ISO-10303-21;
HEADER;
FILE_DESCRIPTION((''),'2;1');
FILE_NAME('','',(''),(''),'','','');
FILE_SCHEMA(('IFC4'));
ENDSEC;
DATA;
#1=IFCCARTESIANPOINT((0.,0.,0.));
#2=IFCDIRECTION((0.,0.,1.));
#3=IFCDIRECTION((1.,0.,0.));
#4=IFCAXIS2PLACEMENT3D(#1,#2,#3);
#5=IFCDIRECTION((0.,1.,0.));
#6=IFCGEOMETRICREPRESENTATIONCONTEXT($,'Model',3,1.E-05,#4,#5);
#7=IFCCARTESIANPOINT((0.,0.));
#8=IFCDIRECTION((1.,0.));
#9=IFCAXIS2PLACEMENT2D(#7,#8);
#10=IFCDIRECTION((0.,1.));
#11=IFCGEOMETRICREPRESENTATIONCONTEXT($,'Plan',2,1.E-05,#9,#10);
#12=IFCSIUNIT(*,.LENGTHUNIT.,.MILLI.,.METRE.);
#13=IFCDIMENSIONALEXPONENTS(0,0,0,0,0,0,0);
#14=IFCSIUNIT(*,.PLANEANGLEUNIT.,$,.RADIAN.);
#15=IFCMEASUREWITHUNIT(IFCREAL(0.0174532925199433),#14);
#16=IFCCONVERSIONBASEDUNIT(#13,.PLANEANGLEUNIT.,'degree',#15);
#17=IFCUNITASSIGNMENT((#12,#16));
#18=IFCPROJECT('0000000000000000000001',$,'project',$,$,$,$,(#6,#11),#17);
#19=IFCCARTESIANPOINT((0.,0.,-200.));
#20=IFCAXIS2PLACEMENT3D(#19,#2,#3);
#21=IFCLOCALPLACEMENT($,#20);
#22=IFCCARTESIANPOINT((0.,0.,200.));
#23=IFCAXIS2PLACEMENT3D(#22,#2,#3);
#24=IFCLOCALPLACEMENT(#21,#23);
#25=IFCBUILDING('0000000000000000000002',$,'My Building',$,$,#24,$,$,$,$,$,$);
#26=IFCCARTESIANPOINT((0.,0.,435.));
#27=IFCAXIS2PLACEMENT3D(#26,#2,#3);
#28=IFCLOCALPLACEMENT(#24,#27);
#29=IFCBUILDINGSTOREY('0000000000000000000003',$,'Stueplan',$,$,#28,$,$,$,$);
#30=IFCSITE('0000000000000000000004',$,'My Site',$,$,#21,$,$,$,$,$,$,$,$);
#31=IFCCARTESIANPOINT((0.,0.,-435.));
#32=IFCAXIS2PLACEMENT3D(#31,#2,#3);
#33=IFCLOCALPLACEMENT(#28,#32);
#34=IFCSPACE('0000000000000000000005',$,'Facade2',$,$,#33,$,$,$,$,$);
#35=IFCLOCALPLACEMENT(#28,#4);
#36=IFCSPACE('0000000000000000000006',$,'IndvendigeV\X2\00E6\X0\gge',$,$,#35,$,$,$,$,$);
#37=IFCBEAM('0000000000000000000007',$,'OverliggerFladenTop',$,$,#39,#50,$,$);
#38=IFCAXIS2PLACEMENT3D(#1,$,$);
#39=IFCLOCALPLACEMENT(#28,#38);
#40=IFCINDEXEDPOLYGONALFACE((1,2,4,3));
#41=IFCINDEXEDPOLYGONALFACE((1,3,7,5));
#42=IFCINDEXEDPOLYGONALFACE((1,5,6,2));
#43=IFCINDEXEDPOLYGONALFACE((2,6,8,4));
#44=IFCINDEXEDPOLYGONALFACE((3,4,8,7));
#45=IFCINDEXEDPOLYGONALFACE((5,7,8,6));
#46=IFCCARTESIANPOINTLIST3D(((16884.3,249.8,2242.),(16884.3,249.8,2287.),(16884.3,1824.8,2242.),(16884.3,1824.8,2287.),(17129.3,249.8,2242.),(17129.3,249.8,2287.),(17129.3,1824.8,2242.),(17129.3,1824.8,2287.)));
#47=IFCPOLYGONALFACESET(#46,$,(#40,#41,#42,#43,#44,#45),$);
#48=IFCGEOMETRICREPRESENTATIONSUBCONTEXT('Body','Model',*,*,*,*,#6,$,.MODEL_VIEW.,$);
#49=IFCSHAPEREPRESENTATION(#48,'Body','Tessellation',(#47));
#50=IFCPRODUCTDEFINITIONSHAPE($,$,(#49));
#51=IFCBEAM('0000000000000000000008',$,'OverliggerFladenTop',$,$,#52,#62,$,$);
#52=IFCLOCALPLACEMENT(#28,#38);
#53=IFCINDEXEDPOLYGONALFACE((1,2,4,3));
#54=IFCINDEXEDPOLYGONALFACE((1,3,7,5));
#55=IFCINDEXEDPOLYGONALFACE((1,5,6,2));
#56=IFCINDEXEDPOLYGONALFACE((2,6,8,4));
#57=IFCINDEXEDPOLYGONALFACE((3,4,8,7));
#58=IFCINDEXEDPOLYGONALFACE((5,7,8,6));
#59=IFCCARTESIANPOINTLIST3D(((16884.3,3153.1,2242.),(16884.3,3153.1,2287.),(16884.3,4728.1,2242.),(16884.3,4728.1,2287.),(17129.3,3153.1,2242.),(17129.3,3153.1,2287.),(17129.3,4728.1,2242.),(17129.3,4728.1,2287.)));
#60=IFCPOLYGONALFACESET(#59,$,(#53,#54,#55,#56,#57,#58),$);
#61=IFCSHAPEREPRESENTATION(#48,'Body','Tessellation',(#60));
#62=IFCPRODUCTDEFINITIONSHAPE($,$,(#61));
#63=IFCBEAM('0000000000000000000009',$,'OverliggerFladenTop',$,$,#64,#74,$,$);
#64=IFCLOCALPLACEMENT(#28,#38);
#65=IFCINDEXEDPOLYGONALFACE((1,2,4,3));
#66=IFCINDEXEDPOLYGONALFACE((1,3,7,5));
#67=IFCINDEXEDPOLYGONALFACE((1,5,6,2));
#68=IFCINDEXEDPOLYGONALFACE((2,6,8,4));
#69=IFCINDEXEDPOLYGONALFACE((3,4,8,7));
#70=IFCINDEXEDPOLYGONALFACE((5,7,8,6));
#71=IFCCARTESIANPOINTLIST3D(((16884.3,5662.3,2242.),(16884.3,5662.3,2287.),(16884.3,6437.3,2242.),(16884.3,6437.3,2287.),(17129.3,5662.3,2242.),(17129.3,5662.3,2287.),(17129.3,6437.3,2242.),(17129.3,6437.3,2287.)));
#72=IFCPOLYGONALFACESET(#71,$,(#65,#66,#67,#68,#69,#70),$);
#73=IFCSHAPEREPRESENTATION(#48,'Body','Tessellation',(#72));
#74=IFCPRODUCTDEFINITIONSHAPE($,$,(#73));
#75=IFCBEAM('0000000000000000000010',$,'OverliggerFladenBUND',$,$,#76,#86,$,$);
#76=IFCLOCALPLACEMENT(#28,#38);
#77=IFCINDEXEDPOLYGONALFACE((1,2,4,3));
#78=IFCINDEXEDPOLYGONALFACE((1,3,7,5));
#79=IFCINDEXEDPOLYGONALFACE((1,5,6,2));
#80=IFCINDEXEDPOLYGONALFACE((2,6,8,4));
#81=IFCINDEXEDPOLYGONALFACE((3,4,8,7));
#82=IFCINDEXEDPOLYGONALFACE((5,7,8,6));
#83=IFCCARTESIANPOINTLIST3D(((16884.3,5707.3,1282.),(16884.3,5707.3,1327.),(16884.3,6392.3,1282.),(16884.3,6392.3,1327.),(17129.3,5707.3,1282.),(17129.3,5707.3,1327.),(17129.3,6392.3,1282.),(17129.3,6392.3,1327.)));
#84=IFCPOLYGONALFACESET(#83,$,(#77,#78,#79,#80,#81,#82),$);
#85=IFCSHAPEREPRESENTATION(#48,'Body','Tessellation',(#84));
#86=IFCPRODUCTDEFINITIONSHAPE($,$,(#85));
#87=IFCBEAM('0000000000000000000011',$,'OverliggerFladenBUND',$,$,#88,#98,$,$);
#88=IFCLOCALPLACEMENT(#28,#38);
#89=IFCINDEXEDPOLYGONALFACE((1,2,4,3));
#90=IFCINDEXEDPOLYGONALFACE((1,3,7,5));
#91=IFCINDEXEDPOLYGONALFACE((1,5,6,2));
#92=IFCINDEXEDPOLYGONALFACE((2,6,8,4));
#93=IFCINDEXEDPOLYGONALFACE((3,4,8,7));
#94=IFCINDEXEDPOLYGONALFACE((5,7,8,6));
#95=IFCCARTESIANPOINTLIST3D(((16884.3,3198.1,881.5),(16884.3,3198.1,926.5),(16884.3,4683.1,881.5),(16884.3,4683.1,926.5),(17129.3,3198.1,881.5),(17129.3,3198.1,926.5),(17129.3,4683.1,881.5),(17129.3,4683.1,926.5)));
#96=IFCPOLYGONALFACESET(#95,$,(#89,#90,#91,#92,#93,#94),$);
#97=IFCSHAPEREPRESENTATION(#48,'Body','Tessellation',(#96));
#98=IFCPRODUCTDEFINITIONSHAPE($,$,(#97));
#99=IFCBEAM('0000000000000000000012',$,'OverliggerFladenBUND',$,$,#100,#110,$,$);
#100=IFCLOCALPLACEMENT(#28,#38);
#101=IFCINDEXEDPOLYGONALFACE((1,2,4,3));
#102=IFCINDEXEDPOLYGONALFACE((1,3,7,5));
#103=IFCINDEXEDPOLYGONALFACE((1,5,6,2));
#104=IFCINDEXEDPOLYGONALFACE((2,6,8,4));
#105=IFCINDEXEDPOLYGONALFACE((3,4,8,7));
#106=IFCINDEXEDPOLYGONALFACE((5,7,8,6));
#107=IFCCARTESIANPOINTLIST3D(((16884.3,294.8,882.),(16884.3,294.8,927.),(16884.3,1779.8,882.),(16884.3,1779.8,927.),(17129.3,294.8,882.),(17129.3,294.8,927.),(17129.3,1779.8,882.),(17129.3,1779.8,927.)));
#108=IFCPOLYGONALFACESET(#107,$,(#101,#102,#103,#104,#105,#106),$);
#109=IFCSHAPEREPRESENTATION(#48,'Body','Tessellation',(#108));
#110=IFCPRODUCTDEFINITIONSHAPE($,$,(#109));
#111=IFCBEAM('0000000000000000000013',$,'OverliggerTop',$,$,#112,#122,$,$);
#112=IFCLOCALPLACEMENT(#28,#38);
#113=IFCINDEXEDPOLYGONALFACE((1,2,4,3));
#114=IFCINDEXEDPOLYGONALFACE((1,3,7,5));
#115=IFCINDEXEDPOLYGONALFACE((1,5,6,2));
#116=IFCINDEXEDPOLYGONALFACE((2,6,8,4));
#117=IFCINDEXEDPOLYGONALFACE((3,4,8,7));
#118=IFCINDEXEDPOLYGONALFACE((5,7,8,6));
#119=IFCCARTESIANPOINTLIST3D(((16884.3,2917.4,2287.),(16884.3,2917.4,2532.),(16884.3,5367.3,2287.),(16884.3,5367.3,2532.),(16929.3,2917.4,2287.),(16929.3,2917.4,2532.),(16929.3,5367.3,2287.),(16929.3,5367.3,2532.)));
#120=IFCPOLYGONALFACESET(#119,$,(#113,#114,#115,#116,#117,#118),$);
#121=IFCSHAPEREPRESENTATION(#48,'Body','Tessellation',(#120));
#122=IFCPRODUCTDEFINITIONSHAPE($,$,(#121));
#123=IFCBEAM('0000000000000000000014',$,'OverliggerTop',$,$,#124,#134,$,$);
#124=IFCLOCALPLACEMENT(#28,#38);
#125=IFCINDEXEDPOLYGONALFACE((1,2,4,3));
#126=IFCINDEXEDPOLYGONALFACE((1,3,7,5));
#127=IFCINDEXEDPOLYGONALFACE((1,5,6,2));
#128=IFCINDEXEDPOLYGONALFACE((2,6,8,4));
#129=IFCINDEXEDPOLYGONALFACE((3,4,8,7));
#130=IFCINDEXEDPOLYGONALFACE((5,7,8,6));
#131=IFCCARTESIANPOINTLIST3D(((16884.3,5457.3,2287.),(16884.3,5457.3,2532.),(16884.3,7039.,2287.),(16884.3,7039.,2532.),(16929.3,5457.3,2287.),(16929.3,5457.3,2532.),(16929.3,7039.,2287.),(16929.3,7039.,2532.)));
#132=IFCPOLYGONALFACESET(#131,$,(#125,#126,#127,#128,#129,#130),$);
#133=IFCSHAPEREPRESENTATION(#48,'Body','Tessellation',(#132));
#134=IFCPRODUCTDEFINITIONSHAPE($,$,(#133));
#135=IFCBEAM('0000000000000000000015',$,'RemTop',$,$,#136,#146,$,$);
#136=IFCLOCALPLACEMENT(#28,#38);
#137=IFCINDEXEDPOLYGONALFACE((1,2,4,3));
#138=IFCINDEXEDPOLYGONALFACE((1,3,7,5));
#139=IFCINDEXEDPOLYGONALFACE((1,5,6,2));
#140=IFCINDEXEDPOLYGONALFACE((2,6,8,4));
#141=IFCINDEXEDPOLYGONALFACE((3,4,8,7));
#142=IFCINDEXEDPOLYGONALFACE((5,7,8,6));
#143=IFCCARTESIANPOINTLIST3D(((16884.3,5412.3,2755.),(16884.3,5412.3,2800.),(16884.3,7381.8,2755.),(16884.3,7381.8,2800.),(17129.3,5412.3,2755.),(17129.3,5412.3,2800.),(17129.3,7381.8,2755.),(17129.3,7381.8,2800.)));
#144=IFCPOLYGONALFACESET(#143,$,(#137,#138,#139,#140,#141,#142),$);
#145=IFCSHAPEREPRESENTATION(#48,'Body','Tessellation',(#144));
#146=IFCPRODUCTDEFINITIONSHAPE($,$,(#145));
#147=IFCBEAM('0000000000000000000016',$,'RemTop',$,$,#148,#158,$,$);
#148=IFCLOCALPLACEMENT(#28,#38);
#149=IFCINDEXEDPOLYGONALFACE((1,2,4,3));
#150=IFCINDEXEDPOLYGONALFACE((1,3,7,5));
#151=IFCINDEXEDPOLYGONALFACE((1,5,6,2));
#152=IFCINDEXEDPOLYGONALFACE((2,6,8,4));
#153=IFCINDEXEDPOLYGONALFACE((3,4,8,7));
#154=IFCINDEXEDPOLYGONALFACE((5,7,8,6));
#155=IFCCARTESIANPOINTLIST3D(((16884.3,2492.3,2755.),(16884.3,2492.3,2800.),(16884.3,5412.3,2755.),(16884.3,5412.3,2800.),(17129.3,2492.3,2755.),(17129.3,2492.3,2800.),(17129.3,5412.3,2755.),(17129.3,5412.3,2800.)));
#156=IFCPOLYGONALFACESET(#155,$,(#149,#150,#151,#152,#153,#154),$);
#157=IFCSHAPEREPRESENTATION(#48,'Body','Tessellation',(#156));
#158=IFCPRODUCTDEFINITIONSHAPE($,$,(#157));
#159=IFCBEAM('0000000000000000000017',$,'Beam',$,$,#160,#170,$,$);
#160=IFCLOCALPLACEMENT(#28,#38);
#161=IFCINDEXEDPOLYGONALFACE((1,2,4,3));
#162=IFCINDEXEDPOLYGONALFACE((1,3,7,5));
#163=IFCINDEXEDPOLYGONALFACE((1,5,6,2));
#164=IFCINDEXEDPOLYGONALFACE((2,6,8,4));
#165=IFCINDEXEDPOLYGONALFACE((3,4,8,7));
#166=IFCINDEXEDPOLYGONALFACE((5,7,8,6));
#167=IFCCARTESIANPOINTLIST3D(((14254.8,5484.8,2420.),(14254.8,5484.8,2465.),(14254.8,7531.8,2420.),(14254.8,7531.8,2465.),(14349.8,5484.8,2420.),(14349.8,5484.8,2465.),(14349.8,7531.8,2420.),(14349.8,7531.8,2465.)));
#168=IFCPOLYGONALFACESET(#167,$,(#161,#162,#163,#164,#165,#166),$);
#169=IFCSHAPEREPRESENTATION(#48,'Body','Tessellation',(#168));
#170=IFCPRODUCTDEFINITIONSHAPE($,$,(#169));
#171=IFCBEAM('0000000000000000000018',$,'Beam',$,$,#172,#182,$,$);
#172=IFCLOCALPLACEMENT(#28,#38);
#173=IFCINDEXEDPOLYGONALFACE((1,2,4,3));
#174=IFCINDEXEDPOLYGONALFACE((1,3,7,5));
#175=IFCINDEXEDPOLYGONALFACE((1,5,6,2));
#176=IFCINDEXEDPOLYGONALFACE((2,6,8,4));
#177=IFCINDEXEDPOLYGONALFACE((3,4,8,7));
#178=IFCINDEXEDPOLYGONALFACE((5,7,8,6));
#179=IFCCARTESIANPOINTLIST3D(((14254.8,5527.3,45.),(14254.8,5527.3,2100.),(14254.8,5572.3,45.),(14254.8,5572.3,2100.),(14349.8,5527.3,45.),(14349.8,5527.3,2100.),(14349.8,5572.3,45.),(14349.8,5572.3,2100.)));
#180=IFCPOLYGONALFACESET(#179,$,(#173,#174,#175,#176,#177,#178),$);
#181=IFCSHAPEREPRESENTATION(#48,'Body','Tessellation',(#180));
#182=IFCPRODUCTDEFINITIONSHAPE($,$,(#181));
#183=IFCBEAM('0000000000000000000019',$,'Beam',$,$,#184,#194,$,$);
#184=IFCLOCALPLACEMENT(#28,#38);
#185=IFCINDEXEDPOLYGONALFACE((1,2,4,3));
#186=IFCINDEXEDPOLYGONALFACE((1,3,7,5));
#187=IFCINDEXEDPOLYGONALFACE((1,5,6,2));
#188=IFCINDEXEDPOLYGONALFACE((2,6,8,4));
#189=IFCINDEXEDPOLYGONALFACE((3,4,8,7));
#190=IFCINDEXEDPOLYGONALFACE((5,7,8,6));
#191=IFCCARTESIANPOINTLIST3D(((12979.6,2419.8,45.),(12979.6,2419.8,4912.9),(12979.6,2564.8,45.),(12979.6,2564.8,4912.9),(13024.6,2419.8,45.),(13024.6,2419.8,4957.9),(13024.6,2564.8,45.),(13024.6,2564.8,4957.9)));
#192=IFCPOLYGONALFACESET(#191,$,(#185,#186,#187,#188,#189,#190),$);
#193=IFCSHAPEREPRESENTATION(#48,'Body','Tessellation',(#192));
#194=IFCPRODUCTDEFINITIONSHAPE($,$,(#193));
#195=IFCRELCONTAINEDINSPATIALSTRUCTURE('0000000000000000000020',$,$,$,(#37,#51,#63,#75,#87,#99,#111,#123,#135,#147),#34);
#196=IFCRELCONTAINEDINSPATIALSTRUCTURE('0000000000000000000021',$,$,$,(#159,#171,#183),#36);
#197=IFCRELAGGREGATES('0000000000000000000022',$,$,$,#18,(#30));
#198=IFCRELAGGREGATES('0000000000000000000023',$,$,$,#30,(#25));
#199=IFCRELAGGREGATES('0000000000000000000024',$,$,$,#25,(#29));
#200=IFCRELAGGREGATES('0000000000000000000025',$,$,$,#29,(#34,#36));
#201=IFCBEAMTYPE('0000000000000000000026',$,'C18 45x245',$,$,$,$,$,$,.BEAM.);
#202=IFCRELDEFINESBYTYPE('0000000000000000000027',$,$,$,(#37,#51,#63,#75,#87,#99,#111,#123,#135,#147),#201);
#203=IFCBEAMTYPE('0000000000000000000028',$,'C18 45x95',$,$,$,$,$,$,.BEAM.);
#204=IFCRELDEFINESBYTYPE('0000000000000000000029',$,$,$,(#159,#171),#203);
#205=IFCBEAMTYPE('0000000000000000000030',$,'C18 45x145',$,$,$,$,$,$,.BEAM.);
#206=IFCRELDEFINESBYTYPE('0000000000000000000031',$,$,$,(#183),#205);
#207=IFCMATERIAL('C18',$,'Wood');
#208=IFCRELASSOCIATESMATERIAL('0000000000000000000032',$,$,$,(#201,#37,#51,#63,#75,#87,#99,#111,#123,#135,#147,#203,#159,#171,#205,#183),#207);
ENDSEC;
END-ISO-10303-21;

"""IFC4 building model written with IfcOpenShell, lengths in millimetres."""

from ifc_helpers import new_model, entity, si_unit, converted_unit, direction, frame, origin_with_axes, origin_2d_with_axis, place, context, subcontext, project, spatial, rectangle, extrude, clip, halfspace, material, material_profile, profile_set, profile_usage, type_object, element, save


model = new_model("IFC4")

# Units and contexts
model_context = context("Model", 3, precision=1e-05, world=origin_with_axes(), true_north=direction((0.0, 1.0, 0.0)))
plan_context = context("Plan", 2, precision=1e-05, world=origin_2d_with_axis(), true_north=direction((0.0, 1.0)))
body_context_1 = subcontext(model_context, "Body", "Model", "MODEL_VIEW")
ifc_project = project(units=[si_unit("LENGTHUNIT", "METRE", prefix="MILLI"), converted_unit("PLANEANGLEUNIT", "degree", entity("IfcReal", 0.0174532925199433), si_unit("PLANEANGLEUNIT", "RADIAN"), dimensions=[0, 0, 0, 0, 0, 0, 0])], contexts=[model_context, plan_context])

# Site, building, storey, space
site_placement = place(None, frame((0.0, 0.0, -200.0), z_axis=(0.0, 0.0, 1.0), x_axis=(1.0, 0.0, 0.0)))
site = spatial("IfcSite", under=ifc_project, at=site_placement, Name="My Site")
building_placement = place(site_placement, frame((0.0, 0.0, 200.0), z_axis=(0.0, 0.0, 1.0), x_axis=(1.0, 0.0, 0.0)))
building = spatial("IfcBuilding", under=site, at=building_placement, Name="My Building")
storey_placement = place(building_placement, frame((0.0, 0.0, 435.0), z_axis=(0.0, 0.0, 1.0), x_axis=(1.0, 0.0, 0.0)))
storey = spatial("IfcBuildingStorey", under=building, at=storey_placement, Name="Stueplan")
space_1_placement = place(storey_placement, frame((0.0, 0.0, -435.0), z_axis=(0.0, 0.0, 1.0), x_axis=(1.0, 0.0, 0.0)))
space_1 = spatial("IfcSpace", under=storey, at=space_1_placement, Name="Facade2")

# Beams
ifc_material = material(Name="C18", Category="Wood")
ifc_material_profile_1 = material_profile(ifc_material, rectangle(XDim=45.0, YDim=245.0), Name="concrete")
ifc_profile_set_1 = profile_set([ifc_material_profile_1], Name="woodStructural")
ifc_profile_usage_1 = profile_usage(ifc_profile_set_1)
beam_type_1 = type_object("IfcBeamType", Name="C18 45x245", PredefinedType="BEAM", material=ifc_profile_set_1)
beam_1_placement = place(space_1_placement, frame((17006.8, 249.8, 2699.5), z_axis=(0.0, 1.0, 0.0), x_axis=(0.0, 0.0, 1.0)))
element("IfcBeam", 1, at=beam_1_placement, inside=space_1, type_object=beam_type_1, material=ifc_profile_usage_1, Name="OverliggerFladenTop", context=body_context_1, shape_type="SweptSolid", body=[
    extrude(rectangle(XDim=45.0, YDim=245.0), origin_with_axes(), (0.0, 0.0, 1.0), 1575.0),
])
ifc_profile_usage_2 = profile_usage(ifc_profile_set_1)
beam_2_placement = place(space_1_placement, frame((17006.8, 3153.1, 2699.5), z_axis=(0.0, 1.0, 0.0), x_axis=(0.0, 0.0, 1.0)))
element("IfcBeam", 2, at=beam_2_placement, inside=space_1, type_object=beam_type_1, material=ifc_profile_usage_2, Name="OverliggerFladenTop", context=body_context_1, shape_type="SweptSolid", body=[
    extrude(rectangle(XDim=45.0, YDim=245.0), origin_with_axes(), (0.0, 0.0, 1.0), 1575.0),
])
ifc_profile_usage_3 = profile_usage(ifc_profile_set_1)
beam_3_placement = place(space_1_placement, frame((17006.8, 5662.3, 2699.5), z_axis=(0.0, 1.0, 0.0), x_axis=(0.0, 0.0, 1.0)))
element("IfcBeam", 3, at=beam_3_placement, inside=space_1, type_object=beam_type_1, material=ifc_profile_usage_3, Name="OverliggerFladenTop", context=body_context_1, shape_type="SweptSolid", body=[
    extrude(rectangle(XDim=45.0, YDim=245.0), origin_with_axes(), (0.0, 0.0, 1.0), 775.0),
])
ifc_profile_usage_4 = profile_usage(ifc_profile_set_1)
beam_4_placement = place(space_1_placement, frame((17006.8, 5707.3, 1739.5), z_axis=(0.0, 1.0, 0.0), x_axis=(0.0, 0.0, 1.0)))
element("IfcBeam", 4, at=beam_4_placement, inside=space_1, type_object=beam_type_1, material=ifc_profile_usage_4, Name="OverliggerFladenBUND", context=body_context_1, shape_type="SweptSolid", body=[
    extrude(rectangle(XDim=45.0, YDim=245.0), origin_with_axes(), (0.0, 0.0, 1.0), 685.0),
])
ifc_profile_usage_5 = profile_usage(ifc_profile_set_1)
beam_5_placement = place(space_1_placement, frame((17006.8, 3198.1, 1339.0), z_axis=(0.0, 1.0, 0.0), x_axis=(0.0, 0.0, 1.0)))
element("IfcBeam", 5, at=beam_5_placement, inside=space_1, type_object=beam_type_1, material=ifc_profile_usage_5, Name="OverliggerFladenBUND", context=body_context_1, shape_type="SweptSolid", body=[
    extrude(rectangle(XDim=45.0, YDim=245.0), origin_with_axes(), (0.0, 0.0, 1.0), 1485.0),
])
ifc_profile_usage_6 = profile_usage(ifc_profile_set_1)
beam_6_placement = place(space_1_placement, frame((17006.8, 294.8, 1339.5), z_axis=(0.0, 1.0, 0.0), x_axis=(0.0, 0.0, 1.0)))
element("IfcBeam", 6, at=beam_6_placement, inside=space_1, type_object=beam_type_1, material=ifc_profile_usage_6, Name="OverliggerFladenBUND", context=body_context_1, shape_type="SweptSolid", body=[
    extrude(rectangle(XDim=45.0, YDim=245.0), origin_with_axes(), (0.0, 0.0, 1.0), 1485.0),
])
ifc_profile_usage_7 = profile_usage(ifc_profile_set_1)
beam_7_placement = place(space_1_placement, frame((16906.8, 2917.4, 2844.5), z_axis=(0.0, 1.0, 0.0), x_axis=(1.0, 0.0, 0.0)))
element("IfcBeam", 7, at=beam_7_placement, inside=space_1, type_object=beam_type_1, material=ifc_profile_usage_7, Name="OverliggerTop", context=body_context_1, shape_type="SweptSolid", body=[
    extrude(rectangle(XDim=45.0, YDim=245.0), origin_with_axes(), (0.0, 0.0, 1.0), 2449.9),
])
ifc_profile_usage_8 = profile_usage(ifc_profile_set_1)
beam_8_placement = place(space_1_placement, frame((16906.8, 5457.3, 2844.5), z_axis=(0.0, 1.0, 0.0), x_axis=(1.0, 0.0, 0.0)))
element("IfcBeam", 8, at=beam_8_placement, inside=space_1, type_object=beam_type_1, material=ifc_profile_usage_8, Name="OverliggerTop", context=body_context_1, shape_type="SweptSolid", body=[
    extrude(rectangle(XDim=45.0, YDim=245.0), origin_with_axes(), (0.0, 0.0, 1.0), 1581.7),
])
ifc_profile_usage_9 = profile_usage(ifc_profile_set_1)
beam_9_placement = place(space_1_placement, frame((17006.8, 5412.3, 3212.5), z_axis=(0.0, 1.0, 0.0), x_axis=(0.0, 0.0, 1.0)))
element("IfcBeam", 9, at=beam_9_placement, inside=space_1, type_object=beam_type_1, material=ifc_profile_usage_9, Name="RemTop", context=body_context_1, shape_type="SweptSolid", body=[
    extrude(rectangle(XDim=45.0, YDim=245.0), origin_with_axes(), (0.0, 0.0, 1.0), 1969.5),
])
ifc_profile_usage_10 = profile_usage(ifc_profile_set_1)
beam_10_placement = place(space_1_placement, frame((17006.8, 2492.3, 3212.5), z_axis=(0.0, 1.0, 0.0), x_axis=(0.0, 0.0, 1.0)))
element("IfcBeam", 10, at=beam_10_placement, inside=space_1, type_object=beam_type_1, material=ifc_profile_usage_10, Name="RemTop", context=body_context_1, shape_type="SweptSolid", body=[
    extrude(rectangle(XDim=45.0, YDim=245.0), origin_with_axes(), (0.0, 0.0, 1.0), 2920.0),
])

# Shared definitions
space_2_placement = place(storey_placement, frame((0.0, 0.0, 0.0), z_axis=(0.0, 0.0, 1.0), x_axis=(1.0, 0.0, 0.0)))
space_2 = spatial("IfcSpace", under=storey, at=space_2_placement, Name="IndvendigeVægge")

# Beams
ifc_material_profile_2 = material_profile(ifc_material, rectangle(XDim=45.0, YDim=95.0))
ifc_profile_set_2 = profile_set([ifc_material_profile_2], Name="woodStructural")
ifc_profile_usage_11 = profile_usage(ifc_profile_set_2, cardinal=5)
beam_type_2 = type_object("IfcBeamType", Name="C18 45x95", PredefinedType="BEAM", material=ifc_profile_set_2)
beam_11_placement = place(space_2_placement, frame((14302.3, 5484.8, 2442.5), z_axis=(0.0, 1.0, 0.0), x_axis=(0.0, 0.0, 1.0)))
element("IfcBeam", 11, at=beam_11_placement, inside=space_2, type_object=beam_type_2, material=ifc_profile_usage_11, Name="Beam", context=body_context_1, shape_type="SweptSolid", body=[
    extrude(rectangle(XDim=45.0, YDim=95.0), origin_with_axes(), (0.0, 0.0, 1.0), 2047.0),
])
ifc_profile_usage_12 = profile_usage(ifc_profile_set_2)
beam_12_placement = place(space_2_placement, frame((14302.3, 5549.8, 45.0), z_axis=(0.0, 0.0, 1.0), x_axis=(0.0, -1.0, 0.0)))
element("IfcBeam", 12, at=beam_12_placement, inside=space_2, type_object=beam_type_2, material=ifc_profile_usage_12, Name="Beam", context=body_context_1, shape_type="SweptSolid", body=[
    extrude(rectangle(XDim=45.0, YDim=95.0), origin_with_axes(), (0.0, 0.0, 1.0), 2055.0),
])
ifc_material_profile_3 = material_profile(ifc_material, rectangle(XDim=45.0, YDim=145.0))
ifc_profile_set_3 = profile_set([ifc_material_profile_3], Name="woodStructural")
ifc_profile_usage_13 = profile_usage(ifc_profile_set_3)
beam_type_3 = type_object("IfcBeamType", Name="C18 45x145", PredefinedType="BEAM", material=ifc_profile_set_3)
beam_13_placement = place(space_2_placement, frame((13002.1, 2492.3, 45.0), z_axis=(0.0, 0.0, 1.0), x_axis=(-1.0, 0.0, 0.0)))
element("IfcBeam", 13, at=beam_13_placement, inside=space_2, type_object=beam_type_3, material=ifc_profile_usage_13, Name="Beam", context=body_context_1, shape_type="Clipping", body=[
    clip(extrude(rectangle(XDim=45.0, YDim=145.0), origin_with_axes(), (0.0, 0.0, 1.0), 5035.4), halfspace(frame((-839.0, 0.0, 5729.4), z_axis=(0.707107, 0.0, 0.707107), x_axis=(0.0, -1.0, 0.0)), False)),
])

save(model, "model.ifc")
